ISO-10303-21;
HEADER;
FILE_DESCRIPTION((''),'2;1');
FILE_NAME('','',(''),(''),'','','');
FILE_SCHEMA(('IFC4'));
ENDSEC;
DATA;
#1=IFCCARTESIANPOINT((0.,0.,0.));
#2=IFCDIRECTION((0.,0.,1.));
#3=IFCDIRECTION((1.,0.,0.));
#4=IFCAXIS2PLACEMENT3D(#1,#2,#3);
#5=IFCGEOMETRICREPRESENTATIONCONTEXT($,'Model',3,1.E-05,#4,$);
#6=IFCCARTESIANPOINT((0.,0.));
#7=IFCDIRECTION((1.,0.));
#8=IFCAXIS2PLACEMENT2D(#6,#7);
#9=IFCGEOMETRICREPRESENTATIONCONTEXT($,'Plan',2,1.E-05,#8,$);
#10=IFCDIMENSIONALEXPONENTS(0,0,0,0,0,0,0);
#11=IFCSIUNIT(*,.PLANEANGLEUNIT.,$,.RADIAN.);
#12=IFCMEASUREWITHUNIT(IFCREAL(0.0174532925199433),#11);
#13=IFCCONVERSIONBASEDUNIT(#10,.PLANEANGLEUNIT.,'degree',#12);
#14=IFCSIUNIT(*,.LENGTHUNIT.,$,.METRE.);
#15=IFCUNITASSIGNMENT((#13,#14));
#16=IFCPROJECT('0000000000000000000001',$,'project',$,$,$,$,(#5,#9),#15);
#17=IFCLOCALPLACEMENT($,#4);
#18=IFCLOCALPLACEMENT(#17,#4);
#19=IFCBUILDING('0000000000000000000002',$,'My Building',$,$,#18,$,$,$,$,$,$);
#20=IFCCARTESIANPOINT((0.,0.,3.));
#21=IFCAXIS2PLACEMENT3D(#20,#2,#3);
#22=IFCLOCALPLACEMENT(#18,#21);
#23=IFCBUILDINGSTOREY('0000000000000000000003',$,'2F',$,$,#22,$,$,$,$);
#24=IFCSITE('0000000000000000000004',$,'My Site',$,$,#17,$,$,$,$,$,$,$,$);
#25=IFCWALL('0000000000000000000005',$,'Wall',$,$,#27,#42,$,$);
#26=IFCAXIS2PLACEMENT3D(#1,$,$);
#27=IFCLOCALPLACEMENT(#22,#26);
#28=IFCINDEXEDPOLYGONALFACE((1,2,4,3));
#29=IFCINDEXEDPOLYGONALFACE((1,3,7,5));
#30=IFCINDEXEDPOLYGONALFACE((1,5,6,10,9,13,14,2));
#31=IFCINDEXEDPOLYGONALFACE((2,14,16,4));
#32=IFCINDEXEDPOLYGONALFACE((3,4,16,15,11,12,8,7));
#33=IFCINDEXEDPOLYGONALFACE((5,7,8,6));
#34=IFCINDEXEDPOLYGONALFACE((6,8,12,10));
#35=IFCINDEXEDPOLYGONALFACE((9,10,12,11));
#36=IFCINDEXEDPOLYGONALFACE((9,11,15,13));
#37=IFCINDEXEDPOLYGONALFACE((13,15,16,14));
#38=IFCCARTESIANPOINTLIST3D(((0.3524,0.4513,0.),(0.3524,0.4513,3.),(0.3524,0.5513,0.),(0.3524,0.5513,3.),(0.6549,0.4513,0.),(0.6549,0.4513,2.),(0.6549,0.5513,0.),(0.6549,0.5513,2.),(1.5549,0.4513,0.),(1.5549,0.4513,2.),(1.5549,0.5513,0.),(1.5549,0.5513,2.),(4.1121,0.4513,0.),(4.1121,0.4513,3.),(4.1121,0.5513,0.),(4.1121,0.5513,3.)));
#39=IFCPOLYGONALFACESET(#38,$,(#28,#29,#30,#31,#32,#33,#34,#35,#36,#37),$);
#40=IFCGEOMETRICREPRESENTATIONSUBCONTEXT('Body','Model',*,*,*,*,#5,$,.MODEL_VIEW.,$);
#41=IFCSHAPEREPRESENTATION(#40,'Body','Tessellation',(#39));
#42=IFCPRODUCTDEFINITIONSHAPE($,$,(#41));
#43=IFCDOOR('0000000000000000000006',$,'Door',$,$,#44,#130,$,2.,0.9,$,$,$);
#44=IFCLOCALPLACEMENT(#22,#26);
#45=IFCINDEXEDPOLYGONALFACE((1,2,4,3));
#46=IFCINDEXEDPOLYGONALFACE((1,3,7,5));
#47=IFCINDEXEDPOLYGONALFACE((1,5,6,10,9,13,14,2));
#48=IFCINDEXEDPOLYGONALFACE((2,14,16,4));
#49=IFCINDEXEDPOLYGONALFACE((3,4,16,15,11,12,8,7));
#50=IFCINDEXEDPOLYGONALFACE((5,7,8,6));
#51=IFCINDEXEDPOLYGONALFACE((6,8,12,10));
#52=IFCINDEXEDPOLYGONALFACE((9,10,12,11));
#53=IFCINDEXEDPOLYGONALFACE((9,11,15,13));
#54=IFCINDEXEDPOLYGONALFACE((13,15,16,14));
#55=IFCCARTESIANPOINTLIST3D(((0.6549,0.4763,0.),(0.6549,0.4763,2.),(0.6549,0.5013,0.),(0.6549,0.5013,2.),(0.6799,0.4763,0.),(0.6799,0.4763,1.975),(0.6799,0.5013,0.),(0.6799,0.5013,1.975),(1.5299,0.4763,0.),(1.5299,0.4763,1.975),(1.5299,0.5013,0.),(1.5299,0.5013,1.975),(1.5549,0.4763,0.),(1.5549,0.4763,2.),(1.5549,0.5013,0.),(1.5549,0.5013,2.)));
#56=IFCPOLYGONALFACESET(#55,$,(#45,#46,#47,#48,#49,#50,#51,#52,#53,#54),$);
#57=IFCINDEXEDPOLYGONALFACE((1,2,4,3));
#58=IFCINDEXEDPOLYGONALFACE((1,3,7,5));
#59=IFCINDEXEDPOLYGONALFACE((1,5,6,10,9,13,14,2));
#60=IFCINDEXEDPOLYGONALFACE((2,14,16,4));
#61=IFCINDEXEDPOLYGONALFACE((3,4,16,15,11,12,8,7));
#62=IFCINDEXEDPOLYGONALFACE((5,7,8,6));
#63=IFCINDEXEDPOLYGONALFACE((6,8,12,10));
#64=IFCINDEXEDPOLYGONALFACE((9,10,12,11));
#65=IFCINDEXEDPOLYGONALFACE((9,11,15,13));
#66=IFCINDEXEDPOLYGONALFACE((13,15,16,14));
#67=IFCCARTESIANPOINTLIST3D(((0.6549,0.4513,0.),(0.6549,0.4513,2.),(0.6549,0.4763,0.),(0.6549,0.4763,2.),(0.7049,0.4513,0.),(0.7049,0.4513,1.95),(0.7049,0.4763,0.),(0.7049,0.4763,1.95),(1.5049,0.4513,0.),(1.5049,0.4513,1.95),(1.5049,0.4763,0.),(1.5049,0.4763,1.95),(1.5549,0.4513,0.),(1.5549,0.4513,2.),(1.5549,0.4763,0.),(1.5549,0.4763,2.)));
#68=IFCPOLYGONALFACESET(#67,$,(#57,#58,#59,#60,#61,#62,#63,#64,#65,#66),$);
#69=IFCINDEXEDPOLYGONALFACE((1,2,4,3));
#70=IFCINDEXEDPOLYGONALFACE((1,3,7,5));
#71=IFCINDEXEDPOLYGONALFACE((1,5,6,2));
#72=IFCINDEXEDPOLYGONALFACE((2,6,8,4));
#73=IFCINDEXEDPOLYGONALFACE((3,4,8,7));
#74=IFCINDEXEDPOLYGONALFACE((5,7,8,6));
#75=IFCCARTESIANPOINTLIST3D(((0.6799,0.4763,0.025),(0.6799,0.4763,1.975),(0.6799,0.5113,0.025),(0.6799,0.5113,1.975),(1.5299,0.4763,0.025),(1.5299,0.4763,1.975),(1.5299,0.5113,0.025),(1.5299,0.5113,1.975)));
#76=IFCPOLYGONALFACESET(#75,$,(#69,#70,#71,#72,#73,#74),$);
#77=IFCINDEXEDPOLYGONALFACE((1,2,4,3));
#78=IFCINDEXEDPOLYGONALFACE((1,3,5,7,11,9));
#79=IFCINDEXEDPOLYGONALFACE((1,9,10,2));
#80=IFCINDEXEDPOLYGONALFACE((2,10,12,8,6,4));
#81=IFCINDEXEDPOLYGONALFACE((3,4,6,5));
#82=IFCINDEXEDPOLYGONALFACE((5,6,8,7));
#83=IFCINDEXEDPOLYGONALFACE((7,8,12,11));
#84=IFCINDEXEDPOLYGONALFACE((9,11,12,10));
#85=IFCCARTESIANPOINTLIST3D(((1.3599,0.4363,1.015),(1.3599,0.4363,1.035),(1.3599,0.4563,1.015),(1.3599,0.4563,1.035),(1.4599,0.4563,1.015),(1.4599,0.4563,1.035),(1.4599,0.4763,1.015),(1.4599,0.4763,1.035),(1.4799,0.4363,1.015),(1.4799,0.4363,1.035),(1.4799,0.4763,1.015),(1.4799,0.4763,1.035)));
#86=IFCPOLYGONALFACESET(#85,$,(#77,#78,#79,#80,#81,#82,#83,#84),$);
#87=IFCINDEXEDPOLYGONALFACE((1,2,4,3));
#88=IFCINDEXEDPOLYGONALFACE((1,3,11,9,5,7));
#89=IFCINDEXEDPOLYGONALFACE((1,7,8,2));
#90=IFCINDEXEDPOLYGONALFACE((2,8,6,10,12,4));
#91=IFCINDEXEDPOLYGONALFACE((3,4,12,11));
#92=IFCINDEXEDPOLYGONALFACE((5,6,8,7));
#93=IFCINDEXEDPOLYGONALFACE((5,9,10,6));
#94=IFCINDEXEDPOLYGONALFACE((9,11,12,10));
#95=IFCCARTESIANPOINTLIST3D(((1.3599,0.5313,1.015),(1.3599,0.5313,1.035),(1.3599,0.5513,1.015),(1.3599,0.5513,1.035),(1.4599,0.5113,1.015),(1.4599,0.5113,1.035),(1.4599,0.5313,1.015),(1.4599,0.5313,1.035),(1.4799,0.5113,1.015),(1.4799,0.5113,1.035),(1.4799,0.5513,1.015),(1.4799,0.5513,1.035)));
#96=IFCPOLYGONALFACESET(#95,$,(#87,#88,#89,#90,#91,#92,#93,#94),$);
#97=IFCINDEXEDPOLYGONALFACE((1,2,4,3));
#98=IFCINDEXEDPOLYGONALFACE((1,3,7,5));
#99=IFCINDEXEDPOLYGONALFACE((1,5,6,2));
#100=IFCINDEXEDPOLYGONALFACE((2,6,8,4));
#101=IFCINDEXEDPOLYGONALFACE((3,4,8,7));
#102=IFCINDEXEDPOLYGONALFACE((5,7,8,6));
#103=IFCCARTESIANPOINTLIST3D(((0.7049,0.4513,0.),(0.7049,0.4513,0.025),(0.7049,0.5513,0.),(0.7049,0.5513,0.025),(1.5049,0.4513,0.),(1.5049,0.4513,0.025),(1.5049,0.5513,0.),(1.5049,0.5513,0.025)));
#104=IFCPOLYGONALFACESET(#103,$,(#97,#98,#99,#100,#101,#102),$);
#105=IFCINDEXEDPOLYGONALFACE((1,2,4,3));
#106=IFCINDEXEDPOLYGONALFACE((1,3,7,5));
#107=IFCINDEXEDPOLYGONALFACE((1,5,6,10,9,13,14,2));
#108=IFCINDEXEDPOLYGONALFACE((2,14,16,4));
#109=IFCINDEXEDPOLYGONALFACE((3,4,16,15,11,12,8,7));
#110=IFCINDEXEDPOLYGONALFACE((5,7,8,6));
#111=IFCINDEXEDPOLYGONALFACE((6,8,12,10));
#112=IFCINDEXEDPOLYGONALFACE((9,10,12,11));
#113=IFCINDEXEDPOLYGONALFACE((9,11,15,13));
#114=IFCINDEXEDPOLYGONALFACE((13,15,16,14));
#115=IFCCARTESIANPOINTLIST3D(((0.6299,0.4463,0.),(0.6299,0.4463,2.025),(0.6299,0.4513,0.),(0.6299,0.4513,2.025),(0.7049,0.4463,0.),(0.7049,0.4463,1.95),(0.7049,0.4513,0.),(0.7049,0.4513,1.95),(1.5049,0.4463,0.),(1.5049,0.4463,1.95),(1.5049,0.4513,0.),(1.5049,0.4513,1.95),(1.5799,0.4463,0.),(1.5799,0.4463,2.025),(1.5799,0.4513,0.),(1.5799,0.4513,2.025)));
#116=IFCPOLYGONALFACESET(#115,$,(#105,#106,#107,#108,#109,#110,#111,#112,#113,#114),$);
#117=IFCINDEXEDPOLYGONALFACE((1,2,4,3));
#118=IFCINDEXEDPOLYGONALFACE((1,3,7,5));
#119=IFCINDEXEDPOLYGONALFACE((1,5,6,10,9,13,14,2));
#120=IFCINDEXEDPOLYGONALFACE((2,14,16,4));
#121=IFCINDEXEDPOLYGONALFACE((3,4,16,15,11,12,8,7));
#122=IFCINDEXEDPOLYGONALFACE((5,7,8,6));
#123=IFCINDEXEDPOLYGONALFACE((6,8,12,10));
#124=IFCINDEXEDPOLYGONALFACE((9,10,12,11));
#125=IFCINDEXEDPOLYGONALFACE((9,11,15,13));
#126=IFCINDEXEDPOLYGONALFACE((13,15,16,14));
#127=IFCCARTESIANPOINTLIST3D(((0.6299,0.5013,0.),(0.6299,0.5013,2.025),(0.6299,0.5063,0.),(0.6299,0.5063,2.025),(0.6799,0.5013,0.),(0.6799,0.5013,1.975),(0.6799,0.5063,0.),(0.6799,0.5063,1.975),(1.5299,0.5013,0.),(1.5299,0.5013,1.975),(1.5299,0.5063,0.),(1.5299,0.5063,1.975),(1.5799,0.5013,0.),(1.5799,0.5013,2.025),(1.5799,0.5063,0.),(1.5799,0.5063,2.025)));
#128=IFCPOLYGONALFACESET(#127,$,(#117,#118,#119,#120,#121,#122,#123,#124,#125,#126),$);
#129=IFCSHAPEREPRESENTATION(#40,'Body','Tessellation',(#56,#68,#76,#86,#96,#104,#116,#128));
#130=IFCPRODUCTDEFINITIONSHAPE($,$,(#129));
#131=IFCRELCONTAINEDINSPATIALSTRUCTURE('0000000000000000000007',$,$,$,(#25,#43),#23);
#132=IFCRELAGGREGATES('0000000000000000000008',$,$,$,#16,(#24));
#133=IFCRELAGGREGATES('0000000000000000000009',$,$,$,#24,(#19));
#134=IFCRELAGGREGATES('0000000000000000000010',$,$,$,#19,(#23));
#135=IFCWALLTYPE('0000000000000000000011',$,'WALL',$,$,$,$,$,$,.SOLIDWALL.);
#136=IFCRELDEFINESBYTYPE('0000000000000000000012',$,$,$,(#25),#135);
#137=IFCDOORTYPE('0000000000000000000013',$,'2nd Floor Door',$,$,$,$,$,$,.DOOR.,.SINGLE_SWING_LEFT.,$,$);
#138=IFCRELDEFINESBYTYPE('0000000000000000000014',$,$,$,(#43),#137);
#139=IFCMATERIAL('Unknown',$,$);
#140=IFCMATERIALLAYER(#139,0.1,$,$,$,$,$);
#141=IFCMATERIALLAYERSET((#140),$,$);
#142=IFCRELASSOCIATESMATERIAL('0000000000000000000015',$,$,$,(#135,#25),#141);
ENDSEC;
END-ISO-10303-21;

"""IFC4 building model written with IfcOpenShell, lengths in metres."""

from ifc_helpers import new_model, entity, si_unit, converted_unit, frame, origin_with_axes, origin_2d_with_axis, place, context, subcontext, project, spatial, line, indexed_curve, outline, extrude, shape, source, transform, mapped, material, layer, layer_set, layer_usage, type_object, type_shapes, element, fill, save


model = new_model("IFC4")

# Units and contexts
model_context = context("Model", 3, precision=1e-05, world=origin_with_axes())
plan_context = context("Plan", 2, precision=1e-05, world=origin_2d_with_axis())
body_context_1 = subcontext(model_context, "Body", "Model", "MODEL_VIEW")
body_context_2 = subcontext(plan_context, "Body", "Plan", "PLAN_VIEW")
ifc_project = project(units=[converted_unit("PLANEANGLEUNIT", "degree", entity("IfcReal", 0.0174532925199433), si_unit("PLANEANGLEUNIT", "RADIAN"), dimensions=[0, 0, 0, 0, 0, 0, 0]), si_unit("LENGTHUNIT", "METRE")], contexts=[model_context, plan_context])

# Site, building, storey
site_placement = place(None, origin_with_axes())
site = spatial("IfcSite", under=ifc_project, at=site_placement, Name="My Site")
building_placement = place(site_placement, origin_with_axes())
building = spatial("IfcBuilding", under=site, at=building_placement, Name="My Building")
storey_placement = place(building_placement, frame((0.0, 0.0, 3.0), z_axis=(0.0, 0.0, 1.0), x_axis=(1.0, 0.0, 0.0)))
storey = spatial("IfcBuildingStorey", under=building, at=storey_placement, Name="2F")

# Shared definitions
ifc_material = material(Name="Unknown")

# Shared definitions
ifc_layer_1 = layer(ifc_material, 0.1)
ifc_layer_set_1 = layer_set([ifc_layer_1])
wall_type = type_object("IfcWallType", Name="WALL", PredefinedType="SOLIDWALL", material=ifc_layer_set_1)

# Shared definitions
shared_shape_1 = source(origin_with_axes(), body_context_1, "Body", "SweptSolid", [
    extrude(outline(indexed_curve([(0.0, 0.0), (0.9, 0.0), (0.9, 2.0), (0.0, 2.0)], segments=[line(1, 2, 3, 4, 1)])), frame((0.0, -0.6, 0.0), z_axis=(0.0, -1.0, 0.0), x_axis=(1.0, 0.0, 0.0)), (0.0, 0.0, -1.0), 1.2),
])
door_type = type_object("IfcDoorType", Name="2nd Floor Door", OperationType="SINGLE_SWING_LEFT", PredefinedType="DOOR")
shared_shape_2 = source(origin_with_axes(), body_context_1, "Body", "SweptSolid", [
    extrude(outline(indexed_curve([(0.0, 0.0), (0.0, 2.0), (0.9, 2.0), (0.9, 0.0), (0.875, 0.0), (0.875, 1.975), (0.025, 1.975), (0.025, 0.0)], segments=[line(1, 2, 3, 4, 5, 6, 7, 8, 1)])), frame((0.0, 0.025, 0.0), z_axis=(0.0, -1.0, 0.0), x_axis=(1.0, 0.0, 0.0)), (0.0, 0.0, -1.0), 0.025),
    extrude(outline(indexed_curve([(0.0, 0.0), (0.0, 2.0), (0.9, 2.0), (0.9, 0.0), (0.85, 0.0), (0.85, 1.95), (0.05, 1.95), (0.05, 0.0)], segments=[line(1, 2, 3, 4, 5, 6, 7, 8, 1)])), frame((0.0, 0.0, 0.0), z_axis=(0.0, -1.0, 0.0), x_axis=(1.0, 0.0, 0.0)), (0.0, 0.0, -1.0), 0.025),
    extrude(outline(indexed_curve([(0.0, 0.0), (0.85, 0.0), (0.85, 0.035), (0.0, 0.035)], segments=[line(1, 2, 3, 4, 1)])), frame((0.025, 0.025, 0.025), z_axis=(0.0, 0.0, 1.0), x_axis=(1.0, 0.0, 0.0)), (0.0, 0.0, 1.0), 1.95),
    extrude(outline(indexed_curve([(0.0, 0.0), (0.0, -0.04), (-0.12, -0.04), (-0.12, -0.02), (-0.02, -0.02), (-0.02, 0.0)], segments=[line(1, 2, 3, 4, 5, 6, 1)])), frame((0.825, 0.025, 1.015), z_axis=(0.0, 0.0, 1.0), x_axis=(1.0, 0.0, 0.0)), (0.0, 0.0, 1.0), 0.02),
    extrude(outline(indexed_curve([(0.0, 0.0), (0.0, 0.04), (-0.12, 0.04), (-0.12, 0.02), (-0.02, 0.02), (-0.02, 0.0)], segments=[line(1, 2, 3, 4, 5, 6, 1)])), frame((0.825, 0.06, 1.015), z_axis=(0.0, 0.0, 1.0), x_axis=(1.0, 0.0, 0.0)), (0.0, 0.0, 1.0), 0.02),
    extrude(outline(indexed_curve([(0.0, 0.0), (0.8, 0.0), (0.8, 0.1), (0.0, 0.1)], segments=[line(1, 2, 3, 4, 1)])), frame((0.05, 0.0, 0.0), z_axis=(0.0, 0.0, 1.0), x_axis=(1.0, 0.0, 0.0)), (0.0, 0.0, 1.0), 0.025),
    extrude(outline(indexed_curve([(0.0, 0.0), (0.0, 2.025), (0.95, 2.025), (0.95, 0.0), (0.875, 0.0), (0.875, 1.95), (0.075, 1.95), (0.075, 0.0)], segments=[line(1, 2, 3, 4, 5, 6, 7, 8, 1)])), frame((-0.025, -0.005, 0.0), z_axis=(0.0, -1.0, 0.0), x_axis=(1.0, 0.0, 0.0)), (0.0, 0.0, -1.0), 0.005),
    extrude(outline(indexed_curve([(0.0, 0.0), (0.0, 2.025), (0.95, 2.025), (0.95, 0.0), (0.9, 0.0), (0.9, 1.975), (0.05, 1.975), (0.05, 0.0)], segments=[line(1, 2, 3, 4, 5, 6, 7, 8, 1)])), frame((-0.025, 0.05, 0.0), z_axis=(0.0, -1.0, 0.0), x_axis=(1.0, 0.0, 0.0)), (0.0, 0.0, -1.0), 0.005),
])
shared_shape_3 = source(origin_with_axes(), body_context_2, "Body", "Curve2D", [
    entity("IfcIndexedPolyCurve", entity("IfcCartesianPointList2D", [[0.0, 0.0], [0.0, 0.05], [0.025, 0.05], [0.025, 0.025], [0.05, 0.025], [0.05, 0.0]]), [entity("IfcLineIndex", [1, 2, 3, 4, 5, 6, 1])]),
    entity("IfcIndexedPolyCurve", entity("IfcCartesianPointList2D", [[0.9, 0.0], [0.9, 0.05], [0.875, 0.05], [0.875, 0.025], [0.85, 0.025], [0.85, 0.0]]), [entity("IfcLineIndex", [1, 2, 3, 4, 5, 6, 1])]),
    entity("IfcTrimmedCurve", entity("IfcEllipse", entity("IfcAxis2Placement2D", entity("IfcCartesianPoint", [0.06, 0.05]), entity("IfcDirection", [1.0, 0.0])), 0.815, 0.85), [entity("IfcCartesianPoint", [0.875, 0.05])], [entity("IfcCartesianPoint", [0.06, 0.9])], True, "CARTESIAN"),
    entity("IfcIndexedPolyCurve", entity("IfcCartesianPointList2D", [[0.025, 0.05], [0.06, 0.05], [0.06, 0.9], [0.025, 0.9]]), [entity("IfcLineIndex", [1, 2, 3, 4, 1])]),
])
type_shapes(door_type, [shared_shape_2, shared_shape_3])

# Wall, opening, door
ifc_layer_usage_1 = layer_usage(ifc_layer_set_1, "AXIS2", "POSITIVE", 0.0)
wall_1_placement = place(storey_placement, frame((0.3524, 0.4513, 0.0), z_axis=(0.0, 0.0, 1.0), x_axis=(1.0, 0.0, 0.0)))
wall_1 = element("IfcWall", 1, at=wall_1_placement, inside=storey, type_object=wall_type, material=ifc_layer_usage_1, Name="Wall", context=body_context_1, shape_type="SweptSolid", body=[
    extrude(outline(indexed_curve([(0.0, 0.0), (0.0, 0.1), (3.7596, 0.1), (3.7596, 0.0)], segments=[line(1, 2, 3, 4, 1)])), origin_with_axes(), (0.0, 0.0, 1.0), 3.0),
])
opening_1_placement = place(wall_1_placement, frame((0.3024, 0.0, 0.0), z_axis=(0.0, 0.0, 1.0), x_axis=(1.0, 0.0, 0.0)))
opening_1 = element("IfcOpeningElement", 2, at=opening_1_placement, cuts=wall_1, PredefinedType="OPENING", context=body_context_1, shape_type="MappedRepresentation", body=[
    mapped(shared_shape_1, transform((0.0, 0.0, 0.0), x_axis=(1.0, 0.0, 0.0), y_axis=(0.0, 1.0, 0.0), z_axis=(0.0, 0.0, 1.0), scale=1.0)),
])
door_1_placement = place(opening_1_placement, origin_with_axes())
door_1 = element("IfcDoor", 3, at=door_1_placement, inside=storey, type_object=door_type, Name="Door", OverallHeight=2.0, OverallWidth=0.9, shapes=[
    shape(body_context_1, "Body", "MappedRepresentation", [mapped(shared_shape_2, transform((0.0, 0.0, 0.0), x_axis=(1.0, 0.0, 0.0), y_axis=(0.0, 1.0, 0.0), z_axis=(0.0, 0.0, 1.0), scale=1.0))]),
    shape(body_context_2, "Body", "MappedRepresentation", [mapped(shared_shape_3, transform((0.0, 0.0, 0.0), x_axis=(1.0, 0.0, 0.0), y_axis=(0.0, 1.0, 0.0), z_axis=(0.0, 0.0, 1.0), scale=1.0))]),
])
fill(opening_1, door_1)

save(model, "model.ifc")
